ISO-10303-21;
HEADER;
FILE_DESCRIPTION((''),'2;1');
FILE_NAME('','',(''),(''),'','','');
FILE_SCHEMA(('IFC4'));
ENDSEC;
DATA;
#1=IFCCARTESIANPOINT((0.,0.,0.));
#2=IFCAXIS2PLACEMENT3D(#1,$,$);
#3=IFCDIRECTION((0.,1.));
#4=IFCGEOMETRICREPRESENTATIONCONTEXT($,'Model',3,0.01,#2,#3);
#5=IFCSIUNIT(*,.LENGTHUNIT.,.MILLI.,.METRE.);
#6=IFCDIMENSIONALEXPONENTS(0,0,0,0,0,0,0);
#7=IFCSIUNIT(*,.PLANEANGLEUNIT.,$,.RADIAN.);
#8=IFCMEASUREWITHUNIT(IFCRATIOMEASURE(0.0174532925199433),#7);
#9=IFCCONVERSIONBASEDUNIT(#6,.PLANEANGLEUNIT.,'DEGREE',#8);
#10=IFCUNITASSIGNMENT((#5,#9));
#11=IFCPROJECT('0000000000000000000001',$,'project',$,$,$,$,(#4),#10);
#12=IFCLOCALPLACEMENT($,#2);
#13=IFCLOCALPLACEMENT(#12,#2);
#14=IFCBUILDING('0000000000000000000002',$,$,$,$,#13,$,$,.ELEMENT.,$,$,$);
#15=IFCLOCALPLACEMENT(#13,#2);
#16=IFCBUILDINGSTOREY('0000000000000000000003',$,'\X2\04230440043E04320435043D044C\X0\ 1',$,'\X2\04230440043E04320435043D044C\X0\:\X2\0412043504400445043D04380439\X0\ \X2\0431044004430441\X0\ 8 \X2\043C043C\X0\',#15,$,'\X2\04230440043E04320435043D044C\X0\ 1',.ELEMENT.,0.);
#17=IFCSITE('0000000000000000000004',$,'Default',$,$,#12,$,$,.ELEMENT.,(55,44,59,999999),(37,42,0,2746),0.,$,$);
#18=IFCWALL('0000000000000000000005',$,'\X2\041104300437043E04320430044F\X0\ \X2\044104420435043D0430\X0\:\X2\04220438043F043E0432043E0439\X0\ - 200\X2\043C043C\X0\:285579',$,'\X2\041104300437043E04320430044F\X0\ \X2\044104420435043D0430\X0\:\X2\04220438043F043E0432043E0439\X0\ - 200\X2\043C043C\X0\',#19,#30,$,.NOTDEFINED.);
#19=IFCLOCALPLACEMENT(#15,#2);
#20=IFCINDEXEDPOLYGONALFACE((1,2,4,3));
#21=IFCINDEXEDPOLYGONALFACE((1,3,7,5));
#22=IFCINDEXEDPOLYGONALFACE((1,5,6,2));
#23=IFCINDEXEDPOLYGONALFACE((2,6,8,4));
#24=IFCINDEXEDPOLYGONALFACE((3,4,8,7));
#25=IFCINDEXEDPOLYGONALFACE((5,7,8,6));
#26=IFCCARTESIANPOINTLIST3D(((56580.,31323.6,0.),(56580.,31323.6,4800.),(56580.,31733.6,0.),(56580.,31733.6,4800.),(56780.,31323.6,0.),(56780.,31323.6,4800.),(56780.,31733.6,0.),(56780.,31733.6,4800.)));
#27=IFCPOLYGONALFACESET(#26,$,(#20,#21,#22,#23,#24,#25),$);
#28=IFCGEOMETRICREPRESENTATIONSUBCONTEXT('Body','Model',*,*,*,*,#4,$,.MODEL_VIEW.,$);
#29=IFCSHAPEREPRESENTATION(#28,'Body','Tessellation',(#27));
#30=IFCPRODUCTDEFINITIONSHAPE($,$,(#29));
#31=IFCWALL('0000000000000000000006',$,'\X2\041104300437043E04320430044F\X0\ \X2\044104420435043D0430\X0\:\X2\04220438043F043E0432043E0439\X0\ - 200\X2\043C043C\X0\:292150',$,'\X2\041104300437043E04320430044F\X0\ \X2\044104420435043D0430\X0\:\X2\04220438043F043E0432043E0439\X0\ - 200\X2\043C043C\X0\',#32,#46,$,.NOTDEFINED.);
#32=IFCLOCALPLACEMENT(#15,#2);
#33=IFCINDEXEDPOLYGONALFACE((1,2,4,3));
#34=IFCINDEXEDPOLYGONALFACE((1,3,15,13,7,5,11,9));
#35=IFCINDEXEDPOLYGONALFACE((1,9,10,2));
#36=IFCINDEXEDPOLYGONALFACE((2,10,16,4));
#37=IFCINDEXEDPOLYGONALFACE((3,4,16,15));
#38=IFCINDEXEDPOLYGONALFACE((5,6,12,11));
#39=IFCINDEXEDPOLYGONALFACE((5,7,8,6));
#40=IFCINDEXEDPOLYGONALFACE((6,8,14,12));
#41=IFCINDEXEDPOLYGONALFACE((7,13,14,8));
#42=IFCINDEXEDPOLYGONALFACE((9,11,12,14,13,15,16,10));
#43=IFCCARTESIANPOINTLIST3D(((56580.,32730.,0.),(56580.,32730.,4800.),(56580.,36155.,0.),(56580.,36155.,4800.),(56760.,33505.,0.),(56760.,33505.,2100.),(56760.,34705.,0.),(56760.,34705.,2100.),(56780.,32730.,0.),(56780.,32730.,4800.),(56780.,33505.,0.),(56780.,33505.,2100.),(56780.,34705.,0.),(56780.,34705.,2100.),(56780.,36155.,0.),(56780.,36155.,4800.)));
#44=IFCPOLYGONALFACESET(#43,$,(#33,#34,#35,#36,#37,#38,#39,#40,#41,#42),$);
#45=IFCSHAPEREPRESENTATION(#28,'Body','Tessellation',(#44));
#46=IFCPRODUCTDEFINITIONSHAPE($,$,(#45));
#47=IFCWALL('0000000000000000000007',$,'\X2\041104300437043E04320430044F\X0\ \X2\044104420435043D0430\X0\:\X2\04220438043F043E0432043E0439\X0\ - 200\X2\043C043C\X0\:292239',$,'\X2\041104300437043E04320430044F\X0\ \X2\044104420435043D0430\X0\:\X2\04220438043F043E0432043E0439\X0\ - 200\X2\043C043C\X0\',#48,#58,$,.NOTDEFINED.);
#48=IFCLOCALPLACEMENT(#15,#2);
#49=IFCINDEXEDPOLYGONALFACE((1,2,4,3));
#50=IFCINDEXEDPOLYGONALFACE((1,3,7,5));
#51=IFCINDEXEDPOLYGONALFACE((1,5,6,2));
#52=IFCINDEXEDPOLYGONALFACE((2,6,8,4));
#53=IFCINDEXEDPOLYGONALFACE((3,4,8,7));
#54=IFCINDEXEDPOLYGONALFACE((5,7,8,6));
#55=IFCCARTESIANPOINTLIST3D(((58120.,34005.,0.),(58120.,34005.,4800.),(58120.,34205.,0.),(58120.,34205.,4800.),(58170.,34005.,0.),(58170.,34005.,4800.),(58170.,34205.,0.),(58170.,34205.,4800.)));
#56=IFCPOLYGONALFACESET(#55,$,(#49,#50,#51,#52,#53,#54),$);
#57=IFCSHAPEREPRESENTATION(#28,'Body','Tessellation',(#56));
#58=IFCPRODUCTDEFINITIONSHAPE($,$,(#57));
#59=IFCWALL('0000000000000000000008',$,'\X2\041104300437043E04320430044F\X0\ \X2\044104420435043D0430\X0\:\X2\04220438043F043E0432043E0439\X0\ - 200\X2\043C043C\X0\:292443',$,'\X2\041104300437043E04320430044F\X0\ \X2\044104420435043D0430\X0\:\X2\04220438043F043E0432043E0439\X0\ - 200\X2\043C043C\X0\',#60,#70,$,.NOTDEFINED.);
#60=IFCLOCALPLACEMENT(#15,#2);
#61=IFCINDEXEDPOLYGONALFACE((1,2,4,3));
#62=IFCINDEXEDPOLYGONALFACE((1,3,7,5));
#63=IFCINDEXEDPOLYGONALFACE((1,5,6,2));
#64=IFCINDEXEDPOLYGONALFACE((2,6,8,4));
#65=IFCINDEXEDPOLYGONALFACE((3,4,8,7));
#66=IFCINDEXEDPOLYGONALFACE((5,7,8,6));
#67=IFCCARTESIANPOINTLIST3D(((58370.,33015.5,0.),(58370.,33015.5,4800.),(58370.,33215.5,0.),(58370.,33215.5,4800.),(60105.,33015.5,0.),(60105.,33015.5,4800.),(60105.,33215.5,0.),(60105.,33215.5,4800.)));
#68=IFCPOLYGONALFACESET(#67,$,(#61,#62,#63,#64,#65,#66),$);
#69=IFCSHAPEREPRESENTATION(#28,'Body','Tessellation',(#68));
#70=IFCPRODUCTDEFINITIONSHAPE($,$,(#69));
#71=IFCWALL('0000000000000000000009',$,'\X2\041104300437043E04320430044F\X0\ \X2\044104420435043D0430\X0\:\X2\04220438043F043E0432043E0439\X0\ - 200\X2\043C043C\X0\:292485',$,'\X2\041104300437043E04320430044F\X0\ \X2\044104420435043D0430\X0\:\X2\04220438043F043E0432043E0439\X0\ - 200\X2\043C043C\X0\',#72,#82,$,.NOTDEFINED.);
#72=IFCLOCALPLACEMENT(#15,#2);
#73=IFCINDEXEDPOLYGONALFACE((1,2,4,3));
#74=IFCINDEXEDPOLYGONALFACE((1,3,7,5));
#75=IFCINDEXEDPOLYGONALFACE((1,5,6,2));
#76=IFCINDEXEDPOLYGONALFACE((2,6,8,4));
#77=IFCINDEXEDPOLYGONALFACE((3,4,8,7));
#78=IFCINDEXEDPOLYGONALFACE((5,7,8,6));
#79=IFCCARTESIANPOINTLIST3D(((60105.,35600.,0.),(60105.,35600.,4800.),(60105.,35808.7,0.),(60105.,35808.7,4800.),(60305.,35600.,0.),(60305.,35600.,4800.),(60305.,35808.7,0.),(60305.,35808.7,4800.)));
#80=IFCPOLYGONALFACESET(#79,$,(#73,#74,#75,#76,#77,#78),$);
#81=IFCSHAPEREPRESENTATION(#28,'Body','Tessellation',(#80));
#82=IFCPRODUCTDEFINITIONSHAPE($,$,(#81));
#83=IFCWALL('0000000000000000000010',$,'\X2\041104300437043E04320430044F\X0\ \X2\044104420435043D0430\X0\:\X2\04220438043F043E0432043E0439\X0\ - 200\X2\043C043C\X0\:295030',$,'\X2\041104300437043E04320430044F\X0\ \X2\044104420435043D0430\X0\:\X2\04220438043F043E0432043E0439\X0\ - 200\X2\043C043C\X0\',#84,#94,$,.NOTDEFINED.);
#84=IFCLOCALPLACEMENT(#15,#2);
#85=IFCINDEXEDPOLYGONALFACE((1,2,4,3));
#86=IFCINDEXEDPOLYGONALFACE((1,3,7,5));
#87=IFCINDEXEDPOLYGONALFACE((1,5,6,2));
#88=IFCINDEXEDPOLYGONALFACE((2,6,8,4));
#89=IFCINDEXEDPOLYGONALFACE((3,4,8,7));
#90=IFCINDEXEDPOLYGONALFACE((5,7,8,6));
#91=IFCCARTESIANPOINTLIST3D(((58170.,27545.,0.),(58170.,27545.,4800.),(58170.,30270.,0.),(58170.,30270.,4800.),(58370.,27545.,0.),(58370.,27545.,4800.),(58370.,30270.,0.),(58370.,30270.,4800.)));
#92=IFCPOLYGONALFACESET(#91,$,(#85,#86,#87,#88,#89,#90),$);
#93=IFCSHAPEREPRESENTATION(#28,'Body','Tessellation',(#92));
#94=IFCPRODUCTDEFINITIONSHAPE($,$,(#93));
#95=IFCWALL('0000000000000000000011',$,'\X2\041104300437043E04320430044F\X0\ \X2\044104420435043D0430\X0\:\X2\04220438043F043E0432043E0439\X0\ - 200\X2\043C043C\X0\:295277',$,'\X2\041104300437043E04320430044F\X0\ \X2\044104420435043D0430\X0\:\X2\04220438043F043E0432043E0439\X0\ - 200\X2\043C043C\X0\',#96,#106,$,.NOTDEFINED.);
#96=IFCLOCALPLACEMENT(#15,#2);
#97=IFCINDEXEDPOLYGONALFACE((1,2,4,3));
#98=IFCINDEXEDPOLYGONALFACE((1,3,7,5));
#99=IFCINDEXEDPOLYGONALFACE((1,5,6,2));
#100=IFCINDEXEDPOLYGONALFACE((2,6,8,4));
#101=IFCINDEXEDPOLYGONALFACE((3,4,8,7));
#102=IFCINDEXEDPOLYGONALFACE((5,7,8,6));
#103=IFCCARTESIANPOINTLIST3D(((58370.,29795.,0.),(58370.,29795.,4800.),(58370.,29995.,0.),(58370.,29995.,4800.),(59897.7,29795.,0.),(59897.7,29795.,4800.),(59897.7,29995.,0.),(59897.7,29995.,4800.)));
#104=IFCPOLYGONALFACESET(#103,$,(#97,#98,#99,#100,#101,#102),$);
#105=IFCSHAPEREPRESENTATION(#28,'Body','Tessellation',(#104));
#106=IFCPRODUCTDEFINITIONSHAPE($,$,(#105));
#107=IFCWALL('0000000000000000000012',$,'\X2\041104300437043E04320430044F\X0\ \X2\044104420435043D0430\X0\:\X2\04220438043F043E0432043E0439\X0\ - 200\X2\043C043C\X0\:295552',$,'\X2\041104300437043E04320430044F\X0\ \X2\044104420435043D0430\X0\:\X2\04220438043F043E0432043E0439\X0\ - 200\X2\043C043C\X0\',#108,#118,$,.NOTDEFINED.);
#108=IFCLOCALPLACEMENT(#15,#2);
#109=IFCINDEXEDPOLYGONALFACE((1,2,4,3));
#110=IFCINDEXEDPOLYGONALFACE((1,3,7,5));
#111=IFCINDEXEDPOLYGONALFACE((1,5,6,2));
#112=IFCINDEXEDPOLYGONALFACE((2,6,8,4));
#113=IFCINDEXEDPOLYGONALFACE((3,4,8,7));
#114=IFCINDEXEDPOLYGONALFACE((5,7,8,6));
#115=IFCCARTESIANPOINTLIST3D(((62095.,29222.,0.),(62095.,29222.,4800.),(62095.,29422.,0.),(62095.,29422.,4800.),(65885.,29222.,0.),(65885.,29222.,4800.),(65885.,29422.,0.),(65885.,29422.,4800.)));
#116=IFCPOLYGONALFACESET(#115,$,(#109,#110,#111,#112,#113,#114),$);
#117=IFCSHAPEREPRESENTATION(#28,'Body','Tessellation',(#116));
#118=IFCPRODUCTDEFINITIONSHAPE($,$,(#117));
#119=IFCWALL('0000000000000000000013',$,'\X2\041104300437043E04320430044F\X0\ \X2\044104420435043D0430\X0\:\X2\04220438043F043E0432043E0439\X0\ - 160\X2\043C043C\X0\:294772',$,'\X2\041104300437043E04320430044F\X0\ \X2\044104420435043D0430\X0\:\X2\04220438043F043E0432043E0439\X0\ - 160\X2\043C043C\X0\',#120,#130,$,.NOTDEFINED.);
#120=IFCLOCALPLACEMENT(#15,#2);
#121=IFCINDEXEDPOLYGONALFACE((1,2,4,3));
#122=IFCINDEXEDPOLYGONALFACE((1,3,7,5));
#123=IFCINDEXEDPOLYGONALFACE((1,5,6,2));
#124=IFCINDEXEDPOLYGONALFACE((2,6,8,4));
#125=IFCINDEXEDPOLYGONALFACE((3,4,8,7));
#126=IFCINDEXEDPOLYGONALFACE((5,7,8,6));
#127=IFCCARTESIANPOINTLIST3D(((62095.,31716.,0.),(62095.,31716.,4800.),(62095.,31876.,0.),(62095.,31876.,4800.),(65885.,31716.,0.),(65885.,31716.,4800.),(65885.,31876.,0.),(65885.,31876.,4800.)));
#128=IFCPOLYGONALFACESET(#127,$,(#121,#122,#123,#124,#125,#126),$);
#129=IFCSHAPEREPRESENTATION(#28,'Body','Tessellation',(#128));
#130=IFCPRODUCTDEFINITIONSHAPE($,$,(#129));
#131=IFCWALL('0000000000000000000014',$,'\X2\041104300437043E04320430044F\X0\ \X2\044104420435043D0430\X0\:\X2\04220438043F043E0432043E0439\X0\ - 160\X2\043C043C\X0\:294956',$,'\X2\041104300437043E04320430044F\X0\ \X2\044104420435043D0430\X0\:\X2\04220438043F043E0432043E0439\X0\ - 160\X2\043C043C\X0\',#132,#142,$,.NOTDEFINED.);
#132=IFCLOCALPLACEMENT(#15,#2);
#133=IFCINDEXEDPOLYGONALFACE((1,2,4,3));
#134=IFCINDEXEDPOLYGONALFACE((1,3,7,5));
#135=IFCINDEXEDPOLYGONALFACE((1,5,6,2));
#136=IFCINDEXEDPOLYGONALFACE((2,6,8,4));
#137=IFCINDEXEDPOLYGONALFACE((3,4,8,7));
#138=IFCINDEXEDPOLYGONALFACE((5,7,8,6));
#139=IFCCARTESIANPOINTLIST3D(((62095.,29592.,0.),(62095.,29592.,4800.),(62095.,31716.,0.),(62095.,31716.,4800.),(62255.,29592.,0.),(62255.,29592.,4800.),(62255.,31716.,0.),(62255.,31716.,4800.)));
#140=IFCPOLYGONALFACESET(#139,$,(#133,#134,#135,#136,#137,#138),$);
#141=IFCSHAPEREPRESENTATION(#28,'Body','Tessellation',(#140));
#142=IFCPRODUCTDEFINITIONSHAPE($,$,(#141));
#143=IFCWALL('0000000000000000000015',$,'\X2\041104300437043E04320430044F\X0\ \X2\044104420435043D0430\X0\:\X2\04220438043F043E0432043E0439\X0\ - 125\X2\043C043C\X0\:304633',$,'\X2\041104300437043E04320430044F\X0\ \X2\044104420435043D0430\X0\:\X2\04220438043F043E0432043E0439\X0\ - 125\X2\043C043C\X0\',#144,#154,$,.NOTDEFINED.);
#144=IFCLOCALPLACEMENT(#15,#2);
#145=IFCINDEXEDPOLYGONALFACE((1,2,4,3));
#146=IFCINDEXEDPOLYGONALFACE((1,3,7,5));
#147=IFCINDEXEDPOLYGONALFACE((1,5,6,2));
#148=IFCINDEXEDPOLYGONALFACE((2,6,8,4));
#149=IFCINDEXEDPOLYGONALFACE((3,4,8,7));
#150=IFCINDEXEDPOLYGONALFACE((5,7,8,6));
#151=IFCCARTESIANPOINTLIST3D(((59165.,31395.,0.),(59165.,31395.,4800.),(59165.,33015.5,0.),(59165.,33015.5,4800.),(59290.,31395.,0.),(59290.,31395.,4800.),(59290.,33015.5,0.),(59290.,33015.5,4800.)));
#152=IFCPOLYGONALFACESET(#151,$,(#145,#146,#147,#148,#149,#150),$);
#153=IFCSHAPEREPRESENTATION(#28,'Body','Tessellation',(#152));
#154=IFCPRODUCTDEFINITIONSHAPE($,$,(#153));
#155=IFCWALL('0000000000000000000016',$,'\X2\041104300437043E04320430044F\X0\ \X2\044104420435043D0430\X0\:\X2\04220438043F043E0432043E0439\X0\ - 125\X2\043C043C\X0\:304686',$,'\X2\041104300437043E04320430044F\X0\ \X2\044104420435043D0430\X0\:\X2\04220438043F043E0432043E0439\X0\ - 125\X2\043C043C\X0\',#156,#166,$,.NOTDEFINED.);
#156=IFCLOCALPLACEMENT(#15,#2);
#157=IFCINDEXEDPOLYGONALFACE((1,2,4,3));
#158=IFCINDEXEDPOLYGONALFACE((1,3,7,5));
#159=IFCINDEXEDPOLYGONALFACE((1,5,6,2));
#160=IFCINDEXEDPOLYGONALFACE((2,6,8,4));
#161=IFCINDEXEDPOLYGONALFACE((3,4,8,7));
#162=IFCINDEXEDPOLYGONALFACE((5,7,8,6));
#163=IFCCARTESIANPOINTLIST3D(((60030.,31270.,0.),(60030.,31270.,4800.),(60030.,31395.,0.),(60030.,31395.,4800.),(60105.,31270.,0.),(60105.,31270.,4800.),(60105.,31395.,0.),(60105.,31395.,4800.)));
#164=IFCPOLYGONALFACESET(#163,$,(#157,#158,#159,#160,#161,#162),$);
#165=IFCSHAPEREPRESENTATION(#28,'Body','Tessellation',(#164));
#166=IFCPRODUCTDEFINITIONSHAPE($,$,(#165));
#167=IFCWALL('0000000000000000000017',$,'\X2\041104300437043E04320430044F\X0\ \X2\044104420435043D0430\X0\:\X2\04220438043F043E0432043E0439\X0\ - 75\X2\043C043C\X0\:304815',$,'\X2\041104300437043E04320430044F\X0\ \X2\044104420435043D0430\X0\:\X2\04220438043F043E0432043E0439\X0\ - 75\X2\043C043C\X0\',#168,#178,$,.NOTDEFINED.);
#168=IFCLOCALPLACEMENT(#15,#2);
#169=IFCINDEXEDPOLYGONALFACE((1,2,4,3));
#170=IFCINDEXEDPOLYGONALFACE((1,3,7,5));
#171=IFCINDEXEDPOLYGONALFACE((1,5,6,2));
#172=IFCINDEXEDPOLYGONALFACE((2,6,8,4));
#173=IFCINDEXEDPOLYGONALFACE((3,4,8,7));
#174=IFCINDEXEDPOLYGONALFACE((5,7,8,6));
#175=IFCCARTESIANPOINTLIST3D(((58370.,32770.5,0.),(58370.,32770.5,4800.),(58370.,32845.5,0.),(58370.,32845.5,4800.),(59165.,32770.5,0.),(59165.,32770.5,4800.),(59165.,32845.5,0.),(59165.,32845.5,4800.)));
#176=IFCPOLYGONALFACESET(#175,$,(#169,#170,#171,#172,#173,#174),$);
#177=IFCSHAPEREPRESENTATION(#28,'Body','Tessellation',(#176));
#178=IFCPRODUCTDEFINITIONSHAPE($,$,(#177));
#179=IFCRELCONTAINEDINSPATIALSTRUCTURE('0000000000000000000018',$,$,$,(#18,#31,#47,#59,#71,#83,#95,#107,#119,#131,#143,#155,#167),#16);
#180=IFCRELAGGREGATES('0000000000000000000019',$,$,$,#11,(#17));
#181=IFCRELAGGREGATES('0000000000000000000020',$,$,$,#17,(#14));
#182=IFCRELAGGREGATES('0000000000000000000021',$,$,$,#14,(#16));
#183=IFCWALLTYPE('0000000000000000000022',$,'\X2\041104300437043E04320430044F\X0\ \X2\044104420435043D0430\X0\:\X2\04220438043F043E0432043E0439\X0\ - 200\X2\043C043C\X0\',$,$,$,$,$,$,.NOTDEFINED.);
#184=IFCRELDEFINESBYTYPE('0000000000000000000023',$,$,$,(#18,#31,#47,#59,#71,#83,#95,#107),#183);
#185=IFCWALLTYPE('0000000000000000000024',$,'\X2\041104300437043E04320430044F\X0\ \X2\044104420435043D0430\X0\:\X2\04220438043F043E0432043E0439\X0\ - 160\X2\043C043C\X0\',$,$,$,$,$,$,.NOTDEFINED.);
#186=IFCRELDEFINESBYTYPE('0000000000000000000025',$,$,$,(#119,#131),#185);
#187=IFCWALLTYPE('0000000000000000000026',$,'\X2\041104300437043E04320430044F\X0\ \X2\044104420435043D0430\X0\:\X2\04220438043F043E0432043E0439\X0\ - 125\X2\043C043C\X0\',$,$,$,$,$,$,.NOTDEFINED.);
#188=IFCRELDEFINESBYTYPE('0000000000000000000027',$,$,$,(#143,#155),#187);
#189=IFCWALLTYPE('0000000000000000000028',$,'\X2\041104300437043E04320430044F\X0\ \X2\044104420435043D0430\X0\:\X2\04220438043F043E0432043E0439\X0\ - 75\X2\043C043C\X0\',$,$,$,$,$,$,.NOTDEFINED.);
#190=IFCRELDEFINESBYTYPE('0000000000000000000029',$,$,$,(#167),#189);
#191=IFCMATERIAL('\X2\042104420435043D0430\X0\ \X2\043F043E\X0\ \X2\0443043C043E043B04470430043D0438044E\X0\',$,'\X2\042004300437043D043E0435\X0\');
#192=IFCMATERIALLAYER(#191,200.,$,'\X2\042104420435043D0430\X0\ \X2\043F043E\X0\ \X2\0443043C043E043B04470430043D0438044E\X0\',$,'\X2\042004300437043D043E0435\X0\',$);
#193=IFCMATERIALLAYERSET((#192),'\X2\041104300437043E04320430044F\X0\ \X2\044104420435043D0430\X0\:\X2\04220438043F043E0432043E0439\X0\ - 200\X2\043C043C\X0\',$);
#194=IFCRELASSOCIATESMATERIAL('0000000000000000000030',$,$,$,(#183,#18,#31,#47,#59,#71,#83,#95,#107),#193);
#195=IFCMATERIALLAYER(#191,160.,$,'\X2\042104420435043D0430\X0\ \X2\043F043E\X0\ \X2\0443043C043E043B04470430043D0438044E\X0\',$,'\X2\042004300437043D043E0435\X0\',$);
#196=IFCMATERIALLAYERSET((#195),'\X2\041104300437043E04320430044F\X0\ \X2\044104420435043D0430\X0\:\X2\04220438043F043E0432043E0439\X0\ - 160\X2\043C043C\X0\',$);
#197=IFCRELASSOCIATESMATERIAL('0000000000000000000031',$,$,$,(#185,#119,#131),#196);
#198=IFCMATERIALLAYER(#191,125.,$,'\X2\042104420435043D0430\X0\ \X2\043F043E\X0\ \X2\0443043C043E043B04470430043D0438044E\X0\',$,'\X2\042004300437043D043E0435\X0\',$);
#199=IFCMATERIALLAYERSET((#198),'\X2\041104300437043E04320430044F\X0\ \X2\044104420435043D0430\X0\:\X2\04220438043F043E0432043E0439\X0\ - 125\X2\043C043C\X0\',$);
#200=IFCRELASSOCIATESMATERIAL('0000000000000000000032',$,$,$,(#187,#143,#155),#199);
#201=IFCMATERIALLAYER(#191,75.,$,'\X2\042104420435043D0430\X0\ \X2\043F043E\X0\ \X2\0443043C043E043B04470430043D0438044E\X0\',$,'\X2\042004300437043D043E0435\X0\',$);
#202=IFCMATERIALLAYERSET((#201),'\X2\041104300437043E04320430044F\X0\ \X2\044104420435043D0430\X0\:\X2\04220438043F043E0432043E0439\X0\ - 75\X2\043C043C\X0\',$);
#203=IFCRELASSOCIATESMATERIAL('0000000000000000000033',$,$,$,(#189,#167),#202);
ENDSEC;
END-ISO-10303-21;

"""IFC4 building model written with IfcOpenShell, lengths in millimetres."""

from ifc_helpers import new_model, entity, si_unit, converted_unit, direction, frame, frame_2d, origin, place, context, subcontext, project, spatial, rectangle, extrude, material, layer, layer_set, layer_usage, type_object, element, save


model = new_model("IFC4")

# Units and contexts
model_context = context("Model", 3, precision=0.01, world=origin(), true_north=direction((0.0, 1.0)))
body_context = subcontext(model_context, "Body", "Model", "MODEL_VIEW")
ifc_project = project(units=[si_unit("LENGTHUNIT", "METRE", prefix="MILLI"), converted_unit("PLANEANGLEUNIT", "DEGREE", entity("IfcRatioMeasure", 0.0174532925199433), si_unit("PLANEANGLEUNIT", "RADIAN"), dimensions=[0, 0, 0, 0, 0, 0, 0])], contexts=[model_context])

# Site, building, storey
site_placement = place(None, origin())
site = spatial("IfcSite", under=ifc_project, at=site_placement, Name="Default", CompositionType="ELEMENT", RefLatitude=(55, 44, 59, 999999), RefLongitude=(37, 42, 0, 2746), RefElevation=0.0)
building_placement = place(site_placement, origin())
building = spatial("IfcBuilding", under=site, at=building_placement, CompositionType="ELEMENT")
storey_placement = place(building_placement, origin())
storey = spatial("IfcBuildingStorey", under=building, at=storey_placement, Name="Уровень 1", ObjectType="Уровень:Верхний брус 8 мм", LongName="Уровень 1", CompositionType="ELEMENT", Elevation=0.0)

# Wall
ifc_material = material(Name="Стена по умолчанию", Category="Разное")
ifc_layer_1 = layer(ifc_material, 200.0, Name="Стена по умолчанию", Category="Разное")
ifc_layer_set_1 = layer_set([ifc_layer_1], Name="Базовая стена:Типовой - 200мм")
ifc_layer_usage_1 = layer_usage(ifc_layer_set_1, "AXIS2", "NEGATIVE", 100.0)
wall_type_1 = type_object("IfcWallType", Name="Базовая стена:Типовой - 200мм", PredefinedType="NOTDEFINED", material=ifc_layer_set_1)
wall_1_placement = place(storey_placement, frame((56680.0, 31733.6, 0.0), z_axis=(0.0, 0.0, 1.0), x_axis=(0.0, -1.0, 0.0)))
element("IfcWall", 1, at=wall_1_placement, inside=storey, type_object=wall_type_1, material=ifc_layer_usage_1, Name="Базовая стена:Типовой - 200мм:285579", ObjectType="Базовая стена:Типовой - 200мм", PredefinedType="NOTDEFINED", context=body_context, shape_type="SweptSolid", body=[
    extrude(rectangle(XDim=410.0, YDim=200.0, at=frame_2d((205.0, 0.0), x_axis=(-1.0, 0.0))), origin(), (0.0, 0.0, 1.0), 4800.0),
])

# Wall, opening
ifc_layer_usage_2 = layer_usage(ifc_layer_set_1, "AXIS2", "NEGATIVE", 100.0)
wall_2_placement = place(storey_placement, frame((56680.0, 32730.0, 0.0), z_axis=(0.0, 0.0, 1.0), x_axis=(0.0, 1.0, 0.0)))
wall_2 = element("IfcWall", 2, at=wall_2_placement, inside=storey, type_object=wall_type_1, material=ifc_layer_usage_2, Name="Базовая стена:Типовой - 200мм:292150", ObjectType="Базовая стена:Типовой - 200мм", PredefinedType="NOTDEFINED", context=body_context, shape_type="SweptSolid", body=[
    extrude(rectangle(XDim=3425.0, YDim=200.0, at=frame_2d((1712.5, 0.0), x_axis=(-1.0, 0.0))), origin(), (0.0, 0.0, 1.0), 4800.0),
])
opening_1_placement = place(wall_2_placement, frame((775.0, -80.0, 0.0)))
element("IfcOpeningElement", 3, at=opening_1_placement, cuts=wall_2, ObjectType="Opening", PredefinedType="OPENING", context=body_context, shape_type="SweptSolid", body=[
    extrude(rectangle(XDim=2100.0, YDim=1200.0, at=frame_2d((0.0, 0.0), x_axis=(0.0, 1.0))), frame((600.0, -1400.0, 1050.0), z_axis=(0.0, 1.0, 0.0), x_axis=(1.0, 0.0, 0.0)), (0.0, 0.0, 1.0), 1400.0),
])

# Wall
ifc_layer_usage_3 = layer_usage(ifc_layer_set_1, "AXIS2", "NEGATIVE", 100.0)
wall_3_placement = place(storey_placement, frame((58120.0, 34105.0, 0.0)))
element("IfcWall", 4, at=wall_3_placement, inside=storey, type_object=wall_type_1, material=ifc_layer_usage_3, Name="Базовая стена:Типовой - 200мм:292239", ObjectType="Базовая стена:Типовой - 200мм", PredefinedType="NOTDEFINED", context=body_context, shape_type="SweptSolid", body=[
    extrude(rectangle(XDim=50.0, YDim=200.0, at=frame_2d((25.0, 0.0), x_axis=(-1.0, 0.0))), origin(), (0.0, 0.0, 1.0), 4800.0),
])

# Walls
ifc_layer_usage_4 = layer_usage(ifc_layer_set_1, "AXIS2", "NEGATIVE", 100.0)
wall_4_placement = place(storey_placement, frame((58370.0, 33115.5, 0.0)))
element("IfcWall", 5, at=wall_4_placement, inside=storey, type_object=wall_type_1, material=ifc_layer_usage_4, Name="Базовая стена:Типовой - 200мм:292443", ObjectType="Базовая стена:Типовой - 200мм", PredefinedType="NOTDEFINED", context=body_context, shape_type="SweptSolid", body=[
    extrude(rectangle(XDim=1735.0, YDim=200.0, at=frame_2d((867.5, 0.0), x_axis=(-1.0, 0.0))), origin(), (0.0, 0.0, 1.0), 4800.0),
])
ifc_layer_usage_5 = layer_usage(ifc_layer_set_1, "AXIS2", "NEGATIVE", 100.0)
wall_5_placement = place(storey_placement, frame((60205.0, 35600.0, 0.0), z_axis=(0.0, 0.0, 1.0), x_axis=(0.0, 1.0, 0.0)))
element("IfcWall", 6, at=wall_5_placement, inside=storey, type_object=wall_type_1, material=ifc_layer_usage_5, Name="Базовая стена:Типовой - 200мм:292485", ObjectType="Базовая стена:Типовой - 200мм", PredefinedType="NOTDEFINED", context=body_context, shape_type="SweptSolid", body=[
    extrude(rectangle(XDim=208.7, YDim=200.0, at=frame_2d((104.4, 0.0), x_axis=(-1.0, 0.0))), origin(), (0.0, 0.0, 1.0), 4800.0),
])

# Wall
ifc_layer_usage_6 = layer_usage(ifc_layer_set_1, "AXIS2", "NEGATIVE", 100.0)
wall_6_placement = place(storey_placement, frame((58270.0, 30270.0, 0.0), z_axis=(0.0, 0.0, 1.0), x_axis=(0.0, -1.0, 0.0)))
element("IfcWall", 7, at=wall_6_placement, inside=storey, type_object=wall_type_1, material=ifc_layer_usage_6, Name="Базовая стена:Типовой - 200мм:295030", ObjectType="Базовая стена:Типовой - 200мм", PredefinedType="NOTDEFINED", context=body_context, shape_type="SweptSolid", body=[
    extrude(rectangle(XDim=2725.0, YDim=200.0, at=frame_2d((1362.5, 0.0), x_axis=(-1.0, 0.0))), origin(), (0.0, 0.0, 1.0), 4800.0),
])

# Walls
ifc_layer_usage_7 = layer_usage(ifc_layer_set_1, "AXIS2", "NEGATIVE", 100.0)
wall_7_placement = place(storey_placement, frame((58370.0, 29895.0, 0.0)))
element("IfcWall", 8, at=wall_7_placement, inside=storey, type_object=wall_type_1, material=ifc_layer_usage_7, Name="Базовая стена:Типовой - 200мм:295277", ObjectType="Базовая стена:Типовой - 200мм", PredefinedType="NOTDEFINED", context=body_context, shape_type="SweptSolid", body=[
    extrude(rectangle(XDim=1527.7, YDim=200.0, at=frame_2d((763.8, 0.0), x_axis=(-1.0, 0.0))), origin(), (0.0, 0.0, 1.0), 4800.0),
])
ifc_layer_usage_8 = layer_usage(ifc_layer_set_1, "AXIS2", "NEGATIVE", 100.0)
wall_8_placement = place(storey_placement, frame((62095.0, 29322.0, 0.0)))
element("IfcWall", 9, at=wall_8_placement, inside=storey, type_object=wall_type_1, material=ifc_layer_usage_8, Name="Базовая стена:Типовой - 200мм:295552", ObjectType="Базовая стена:Типовой - 200мм", PredefinedType="NOTDEFINED", context=body_context, shape_type="SweptSolid", body=[
    extrude(rectangle(XDim=3790.0, YDim=200.0, at=frame_2d((1895.0, 0.0), x_axis=(-1.0, 0.0))), origin(), (0.0, 0.0, 1.0), 4800.0),
])

# Walls
ifc_layer_2 = layer(ifc_material, 160.0, Name="Стена по умолчанию", Category="Разное")
ifc_layer_set_2 = layer_set([ifc_layer_2], Name="Базовая стена:Типовой - 160мм")
ifc_layer_usage_9 = layer_usage(ifc_layer_set_2, "AXIS2", "NEGATIVE", 80.0)
wall_type_2 = type_object("IfcWallType", Name="Базовая стена:Типовой - 160мм", PredefinedType="NOTDEFINED", material=ifc_layer_set_2)
wall_9_placement = place(storey_placement, frame((62095.0, 31796.0, 0.0)))
element("IfcWall", 10, at=wall_9_placement, inside=storey, type_object=wall_type_2, material=ifc_layer_usage_9, Name="Базовая стена:Типовой - 160мм:294772", ObjectType="Базовая стена:Типовой - 160мм", PredefinedType="NOTDEFINED", context=body_context, shape_type="SweptSolid", body=[
    extrude(rectangle(XDim=3790.0, YDim=160.0, at=frame_2d((1895.0, 0.0), x_axis=(-1.0, 0.0))), origin(), (0.0, 0.0, 1.0), 4800.0),
])
ifc_layer_usage_10 = layer_usage(ifc_layer_set_2, "AXIS2", "NEGATIVE", 80.0)
wall_10_placement = place(storey_placement, frame((62175.0, 29592.0, 0.0), z_axis=(0.0, 0.0, 1.0), x_axis=(0.0, 1.0, 0.0)))
element("IfcWall", 11, at=wall_10_placement, inside=storey, type_object=wall_type_2, material=ifc_layer_usage_10, Name="Базовая стена:Типовой - 160мм:294956", ObjectType="Базовая стена:Типовой - 160мм", PredefinedType="NOTDEFINED", context=body_context, shape_type="SweptSolid", body=[
    extrude(rectangle(XDim=2124.0, YDim=160.0, at=frame_2d((1062.0, 0.0), x_axis=(-1.0, 0.0))), origin(), (0.0, 0.0, 1.0), 4800.0),
])

# Shared definitions
ifc_layer_3 = layer(ifc_material, 125.0, Name="Стена по умолчанию", Category="Разное")
ifc_layer_set_3 = layer_set([ifc_layer_3], Name="Базовая стена:Типовой - 125мм")
wall_type_3 = type_object("IfcWallType", Name="Базовая стена:Типовой - 125мм", PredefinedType="NOTDEFINED", material=ifc_layer_set_3)

# Walls
ifc_layer_usage_11 = layer_usage(ifc_layer_set_3, "AXIS2", "NEGATIVE", 62.5)
wall_11_placement = place(storey_placement, frame((59227.5, 31395.0, 0.0), z_axis=(0.0, 0.0, 1.0), x_axis=(0.0, 1.0, 0.0)))
element("IfcWall", 12, at=wall_11_placement, inside=storey, type_object=wall_type_3, material=ifc_layer_usage_11, Name="Базовая стена:Типовой - 125мм:304633", ObjectType="Базовая стена:Типовой - 125мм", PredefinedType="NOTDEFINED", context=body_context, shape_type="SweptSolid", body=[
    extrude(rectangle(XDim=1620.5, YDim=125.0, at=frame_2d((810.3, 0.0), x_axis=(-1.0, 0.0))), origin(), (0.0, 0.0, 1.0), 4800.0),
])
ifc_layer_usage_12 = layer_usage(ifc_layer_set_3, "AXIS2", "NEGATIVE", 62.5)
wall_12_placement = place(storey_placement, frame((60030.0, 31332.5, 0.0)))
element("IfcWall", 13, at=wall_12_placement, inside=storey, type_object=wall_type_3, material=ifc_layer_usage_12, Name="Базовая стена:Типовой - 125мм:304686", ObjectType="Базовая стена:Типовой - 125мм", PredefinedType="NOTDEFINED", context=body_context, shape_type="SweptSolid", body=[
    extrude(rectangle(XDim=75.0, YDim=125.0, at=frame_2d((37.5, 0.0), x_axis=(-1.0, 0.0))), origin(), (0.0, 0.0, 1.0), 4800.0),
])
ifc_layer_4 = layer(ifc_material, 75.0, Name="Стена по умолчанию", Category="Разное")
ifc_layer_set_4 = layer_set([ifc_layer_4], Name="Базовая стена:Типовой - 75мм")
ifc_layer_usage_13 = layer_usage(ifc_layer_set_4, "AXIS2", "NEGATIVE", 37.5)
wall_type_4 = type_object("IfcWallType", Name="Базовая стена:Типовой - 75мм", PredefinedType="NOTDEFINED", material=ifc_layer_set_4)
wall_13_placement = place(storey_placement, frame((58370.0, 32808.0, 0.0)))
element("IfcWall", 14, at=wall_13_placement, inside=storey, type_object=wall_type_4, material=ifc_layer_usage_13, Name="Базовая стена:Типовой - 75мм:304815", ObjectType="Базовая стена:Типовой - 75мм", PredefinedType="NOTDEFINED", context=body_context, shape_type="SweptSolid", body=[
    extrude(rectangle(XDim=795.0, YDim=75.0, at=frame_2d((397.5, 0.0), x_axis=(-1.0, 0.0))), origin(), (0.0, 0.0, 1.0), 4800.0),
])

save(model, "model.ifc")
